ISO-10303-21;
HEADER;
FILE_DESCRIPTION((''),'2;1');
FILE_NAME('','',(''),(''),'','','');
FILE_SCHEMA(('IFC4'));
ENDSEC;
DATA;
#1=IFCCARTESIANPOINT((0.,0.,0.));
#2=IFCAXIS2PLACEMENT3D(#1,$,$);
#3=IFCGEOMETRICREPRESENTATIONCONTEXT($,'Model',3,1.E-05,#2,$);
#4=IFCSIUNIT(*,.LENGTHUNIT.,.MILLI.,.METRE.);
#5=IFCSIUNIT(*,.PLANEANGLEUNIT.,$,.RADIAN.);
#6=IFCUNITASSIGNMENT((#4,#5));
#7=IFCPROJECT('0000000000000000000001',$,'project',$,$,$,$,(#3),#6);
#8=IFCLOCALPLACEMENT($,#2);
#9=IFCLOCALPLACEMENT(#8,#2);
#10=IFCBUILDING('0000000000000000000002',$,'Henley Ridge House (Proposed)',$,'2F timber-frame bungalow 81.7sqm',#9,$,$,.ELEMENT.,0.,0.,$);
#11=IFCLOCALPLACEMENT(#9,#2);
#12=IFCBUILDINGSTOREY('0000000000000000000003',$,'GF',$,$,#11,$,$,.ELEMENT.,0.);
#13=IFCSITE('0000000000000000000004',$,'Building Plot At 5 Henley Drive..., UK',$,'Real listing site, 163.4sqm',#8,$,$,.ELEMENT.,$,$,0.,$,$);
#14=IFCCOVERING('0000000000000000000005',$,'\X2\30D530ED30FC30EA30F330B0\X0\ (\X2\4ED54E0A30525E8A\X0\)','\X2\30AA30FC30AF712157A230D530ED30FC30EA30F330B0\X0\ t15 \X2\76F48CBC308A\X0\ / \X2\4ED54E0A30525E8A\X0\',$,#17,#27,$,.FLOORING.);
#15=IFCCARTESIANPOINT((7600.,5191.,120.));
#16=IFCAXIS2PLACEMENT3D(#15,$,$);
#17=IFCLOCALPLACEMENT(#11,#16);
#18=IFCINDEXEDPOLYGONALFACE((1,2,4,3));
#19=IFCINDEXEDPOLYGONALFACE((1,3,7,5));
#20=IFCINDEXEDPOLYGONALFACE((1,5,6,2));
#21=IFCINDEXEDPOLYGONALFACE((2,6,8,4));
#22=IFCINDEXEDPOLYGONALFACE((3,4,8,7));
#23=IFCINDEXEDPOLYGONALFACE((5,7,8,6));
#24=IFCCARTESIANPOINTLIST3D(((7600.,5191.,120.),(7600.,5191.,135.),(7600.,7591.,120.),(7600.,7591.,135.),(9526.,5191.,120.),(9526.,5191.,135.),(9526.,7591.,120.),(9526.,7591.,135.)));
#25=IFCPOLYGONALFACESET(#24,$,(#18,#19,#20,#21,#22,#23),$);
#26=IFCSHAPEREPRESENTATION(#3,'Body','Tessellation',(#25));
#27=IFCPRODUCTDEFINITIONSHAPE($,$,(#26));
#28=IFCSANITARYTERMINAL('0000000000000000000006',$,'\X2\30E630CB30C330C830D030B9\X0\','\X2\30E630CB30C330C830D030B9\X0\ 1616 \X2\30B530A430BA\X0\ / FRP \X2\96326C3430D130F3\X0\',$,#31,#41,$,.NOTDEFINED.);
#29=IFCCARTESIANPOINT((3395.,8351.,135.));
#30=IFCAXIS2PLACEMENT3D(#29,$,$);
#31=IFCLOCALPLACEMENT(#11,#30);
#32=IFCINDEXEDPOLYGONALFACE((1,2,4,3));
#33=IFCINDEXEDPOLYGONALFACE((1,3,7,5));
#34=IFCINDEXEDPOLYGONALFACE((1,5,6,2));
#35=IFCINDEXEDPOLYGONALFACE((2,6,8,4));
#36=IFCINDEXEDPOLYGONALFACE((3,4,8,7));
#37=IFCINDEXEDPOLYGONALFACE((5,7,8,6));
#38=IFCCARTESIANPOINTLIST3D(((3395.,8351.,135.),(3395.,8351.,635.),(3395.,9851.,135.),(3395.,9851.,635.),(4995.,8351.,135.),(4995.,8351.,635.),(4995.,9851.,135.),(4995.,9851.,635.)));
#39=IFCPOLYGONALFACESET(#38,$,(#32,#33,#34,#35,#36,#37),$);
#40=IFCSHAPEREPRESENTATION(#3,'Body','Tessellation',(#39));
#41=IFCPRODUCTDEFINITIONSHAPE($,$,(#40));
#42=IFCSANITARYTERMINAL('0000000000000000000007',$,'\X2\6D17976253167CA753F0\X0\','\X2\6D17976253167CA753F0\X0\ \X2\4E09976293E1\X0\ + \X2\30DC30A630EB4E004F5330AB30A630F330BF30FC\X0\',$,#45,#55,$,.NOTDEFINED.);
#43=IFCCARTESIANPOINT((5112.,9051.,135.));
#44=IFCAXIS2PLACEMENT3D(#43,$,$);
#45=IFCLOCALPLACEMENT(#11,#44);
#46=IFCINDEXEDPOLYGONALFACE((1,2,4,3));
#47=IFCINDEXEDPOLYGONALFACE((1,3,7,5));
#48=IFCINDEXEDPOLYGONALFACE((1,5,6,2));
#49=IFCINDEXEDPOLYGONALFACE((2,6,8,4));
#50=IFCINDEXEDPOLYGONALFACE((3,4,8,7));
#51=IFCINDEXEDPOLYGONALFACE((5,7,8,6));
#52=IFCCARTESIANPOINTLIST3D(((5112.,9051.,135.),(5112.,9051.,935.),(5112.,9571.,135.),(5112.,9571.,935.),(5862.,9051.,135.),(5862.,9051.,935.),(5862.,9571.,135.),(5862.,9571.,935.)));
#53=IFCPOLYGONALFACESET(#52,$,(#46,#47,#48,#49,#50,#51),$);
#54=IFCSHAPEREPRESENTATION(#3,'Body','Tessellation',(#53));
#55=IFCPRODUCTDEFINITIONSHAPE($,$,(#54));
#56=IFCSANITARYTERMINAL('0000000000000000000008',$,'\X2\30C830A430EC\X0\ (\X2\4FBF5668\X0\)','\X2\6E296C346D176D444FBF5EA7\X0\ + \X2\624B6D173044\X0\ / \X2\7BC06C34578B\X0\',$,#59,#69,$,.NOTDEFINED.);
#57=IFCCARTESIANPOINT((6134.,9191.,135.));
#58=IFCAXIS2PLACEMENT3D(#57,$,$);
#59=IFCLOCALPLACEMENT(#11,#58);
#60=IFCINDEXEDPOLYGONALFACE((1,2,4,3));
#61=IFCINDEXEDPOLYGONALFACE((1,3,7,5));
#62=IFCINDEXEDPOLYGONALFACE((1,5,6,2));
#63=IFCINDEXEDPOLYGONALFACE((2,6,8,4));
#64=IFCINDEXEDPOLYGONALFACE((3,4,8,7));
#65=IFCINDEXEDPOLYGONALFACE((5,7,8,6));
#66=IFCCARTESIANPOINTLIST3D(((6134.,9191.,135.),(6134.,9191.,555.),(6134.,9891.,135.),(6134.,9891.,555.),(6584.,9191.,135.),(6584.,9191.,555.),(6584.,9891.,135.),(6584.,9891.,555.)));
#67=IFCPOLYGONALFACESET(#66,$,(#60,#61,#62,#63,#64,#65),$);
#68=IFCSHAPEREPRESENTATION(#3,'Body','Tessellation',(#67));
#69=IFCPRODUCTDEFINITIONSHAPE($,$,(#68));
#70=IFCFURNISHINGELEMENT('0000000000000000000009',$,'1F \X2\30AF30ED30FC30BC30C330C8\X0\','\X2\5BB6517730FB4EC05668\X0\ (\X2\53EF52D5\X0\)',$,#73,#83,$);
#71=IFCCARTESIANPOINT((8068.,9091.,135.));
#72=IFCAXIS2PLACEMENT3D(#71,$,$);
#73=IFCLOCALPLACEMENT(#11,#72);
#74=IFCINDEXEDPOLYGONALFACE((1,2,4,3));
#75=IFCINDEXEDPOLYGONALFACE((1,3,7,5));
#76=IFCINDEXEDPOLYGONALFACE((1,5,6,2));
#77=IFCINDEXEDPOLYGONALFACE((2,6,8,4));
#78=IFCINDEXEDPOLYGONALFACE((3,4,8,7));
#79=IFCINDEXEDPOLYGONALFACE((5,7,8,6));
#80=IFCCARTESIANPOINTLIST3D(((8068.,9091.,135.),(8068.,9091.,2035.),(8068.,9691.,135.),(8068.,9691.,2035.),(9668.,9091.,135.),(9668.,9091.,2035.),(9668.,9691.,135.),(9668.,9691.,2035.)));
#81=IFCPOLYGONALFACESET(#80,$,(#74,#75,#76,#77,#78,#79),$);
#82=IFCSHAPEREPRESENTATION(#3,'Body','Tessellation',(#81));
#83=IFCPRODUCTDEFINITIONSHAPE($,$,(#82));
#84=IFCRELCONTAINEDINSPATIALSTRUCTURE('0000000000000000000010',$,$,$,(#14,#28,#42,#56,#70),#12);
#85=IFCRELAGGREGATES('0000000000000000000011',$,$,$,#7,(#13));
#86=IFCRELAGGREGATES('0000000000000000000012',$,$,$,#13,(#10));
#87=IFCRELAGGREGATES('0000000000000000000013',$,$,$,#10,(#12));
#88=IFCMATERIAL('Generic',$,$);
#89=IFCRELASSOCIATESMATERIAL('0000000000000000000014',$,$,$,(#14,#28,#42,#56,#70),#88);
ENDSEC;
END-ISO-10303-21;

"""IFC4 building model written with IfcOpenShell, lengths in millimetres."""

from ifc_helpers import new_model, si_unit, frame, frame_2d, origin, place, context, project, spatial, rectangle, extrude, material, element, save


model = new_model("IFC4")

# Units and contexts
model_context = context("Model", 3, precision=1e-05, world=origin())
ifc_project = project(units=[si_unit("LENGTHUNIT", "METRE", prefix="MILLI"), si_unit("PLANEANGLEUNIT", "RADIAN")], contexts=[model_context])

# Site, building, storey
site_placement = place(None, origin())
site = spatial("IfcSite", under=ifc_project, at=site_placement, Name="Building Plot At 5 Henley Drive..., UK", ObjectType="Real listing site, 163.4sqm", CompositionType="ELEMENT", RefElevation=0.0)
building_placement = place(site_placement, origin())
building = spatial("IfcBuilding", under=site, at=building_placement, Name="Henley Ridge House (Proposed)", ObjectType="2F timber-frame bungalow 81.7sqm", CompositionType="ELEMENT", ElevationOfRefHeight=0.0, ElevationOfTerrain=0.0)
storey_placement = place(building_placement, origin())
storey = spatial("IfcBuildingStorey", under=building, at=storey_placement, Name="GF", CompositionType="ELEMENT", Elevation=0.0)

# Covering
ifc_material_1 = material(Name="Generic")
covering_1_placement = place(storey_placement, frame((7600.0, 5191.0, 120.0)))
element("IfcCovering", 1, at=covering_1_placement, inside=storey, material=ifc_material_1, Name="フローリング (仕上げ床)", Description="オーク無垢フローリング t15 直貼り / 仕上げ床", PredefinedType="FLOORING", context=model_context, shape_type="SweptSolid", body=[
    extrude(rectangle(XDim=1926.0, YDim=2400.0, at=frame_2d((963.0, 1200.0))), frame((7600.0, 5191.0, 120.0)), (0.0, 0.0, 1.0), 15.0),
])

# Sanitary terminals
sanitary_terminal_1_placement = place(storey_placement, frame((3395.0, 8351.0, 135.0)))
element("IfcSanitaryTerminal", 2, at=sanitary_terminal_1_placement, inside=storey, material=ifc_material_1, Name="ユニットバス", Description="ユニットバス 1616 サイズ / FRP 防水パン", PredefinedType="NOTDEFINED", context=model_context, shape_type="SweptSolid", body=[
    extrude(rectangle(XDim=1600.0, YDim=1500.0, at=frame_2d((800.0, 750.0))), frame((3395.0, 8351.0, 135.0)), (0.0, 0.0, 1.0), 500.0),
])
sanitary_terminal_2_placement = place(storey_placement, frame((5112.0, 9051.0, 135.0)))
element("IfcSanitaryTerminal", 3, at=sanitary_terminal_2_placement, inside=storey, material=ifc_material_1, Name="洗面化粧台", Description="洗面化粧台 三面鏡 + ボウル一体カウンター", PredefinedType="NOTDEFINED", context=model_context, shape_type="SweptSolid", body=[
    extrude(rectangle(XDim=750.0, YDim=520.0, at=frame_2d((375.0, 260.0))), frame((5112.0, 9051.0, 135.0)), (0.0, 0.0, 1.0), 800.0),
])
sanitary_terminal_3_placement = place(storey_placement, frame((6134.0, 9191.0, 135.0)))
element("IfcSanitaryTerminal", 4, at=sanitary_terminal_3_placement, inside=storey, material=ifc_material_1, Name="トイレ (便器)", Description="温水洗浄便座 + 手洗い / 節水型", PredefinedType="NOTDEFINED", context=model_context, shape_type="SweptSolid", body=[
    extrude(rectangle(XDim=450.0, YDim=700.0, at=frame_2d((225.0, 350.0))), frame((6134.0, 9191.0, 135.0)), (0.0, 0.0, 1.0), 420.0),
])

# Furnishing element
furnishing_placement = place(storey_placement, frame((8068.0, 9091.0, 135.0)))
element("IfcFurnishingElement", 5, at=furnishing_placement, inside=storey, material=ifc_material_1, Name="1F クローゼット", Description="家具・什器 (可動)", context=model_context, shape_type="SweptSolid", body=[
    extrude(rectangle(XDim=1600.0, YDim=600.0, at=frame_2d((800.0, 300.0))), frame((8068.0, 9091.0, 135.0)), (0.0, 0.0, 1.0), 1900.0),
])

save(model, "model.ifc")
